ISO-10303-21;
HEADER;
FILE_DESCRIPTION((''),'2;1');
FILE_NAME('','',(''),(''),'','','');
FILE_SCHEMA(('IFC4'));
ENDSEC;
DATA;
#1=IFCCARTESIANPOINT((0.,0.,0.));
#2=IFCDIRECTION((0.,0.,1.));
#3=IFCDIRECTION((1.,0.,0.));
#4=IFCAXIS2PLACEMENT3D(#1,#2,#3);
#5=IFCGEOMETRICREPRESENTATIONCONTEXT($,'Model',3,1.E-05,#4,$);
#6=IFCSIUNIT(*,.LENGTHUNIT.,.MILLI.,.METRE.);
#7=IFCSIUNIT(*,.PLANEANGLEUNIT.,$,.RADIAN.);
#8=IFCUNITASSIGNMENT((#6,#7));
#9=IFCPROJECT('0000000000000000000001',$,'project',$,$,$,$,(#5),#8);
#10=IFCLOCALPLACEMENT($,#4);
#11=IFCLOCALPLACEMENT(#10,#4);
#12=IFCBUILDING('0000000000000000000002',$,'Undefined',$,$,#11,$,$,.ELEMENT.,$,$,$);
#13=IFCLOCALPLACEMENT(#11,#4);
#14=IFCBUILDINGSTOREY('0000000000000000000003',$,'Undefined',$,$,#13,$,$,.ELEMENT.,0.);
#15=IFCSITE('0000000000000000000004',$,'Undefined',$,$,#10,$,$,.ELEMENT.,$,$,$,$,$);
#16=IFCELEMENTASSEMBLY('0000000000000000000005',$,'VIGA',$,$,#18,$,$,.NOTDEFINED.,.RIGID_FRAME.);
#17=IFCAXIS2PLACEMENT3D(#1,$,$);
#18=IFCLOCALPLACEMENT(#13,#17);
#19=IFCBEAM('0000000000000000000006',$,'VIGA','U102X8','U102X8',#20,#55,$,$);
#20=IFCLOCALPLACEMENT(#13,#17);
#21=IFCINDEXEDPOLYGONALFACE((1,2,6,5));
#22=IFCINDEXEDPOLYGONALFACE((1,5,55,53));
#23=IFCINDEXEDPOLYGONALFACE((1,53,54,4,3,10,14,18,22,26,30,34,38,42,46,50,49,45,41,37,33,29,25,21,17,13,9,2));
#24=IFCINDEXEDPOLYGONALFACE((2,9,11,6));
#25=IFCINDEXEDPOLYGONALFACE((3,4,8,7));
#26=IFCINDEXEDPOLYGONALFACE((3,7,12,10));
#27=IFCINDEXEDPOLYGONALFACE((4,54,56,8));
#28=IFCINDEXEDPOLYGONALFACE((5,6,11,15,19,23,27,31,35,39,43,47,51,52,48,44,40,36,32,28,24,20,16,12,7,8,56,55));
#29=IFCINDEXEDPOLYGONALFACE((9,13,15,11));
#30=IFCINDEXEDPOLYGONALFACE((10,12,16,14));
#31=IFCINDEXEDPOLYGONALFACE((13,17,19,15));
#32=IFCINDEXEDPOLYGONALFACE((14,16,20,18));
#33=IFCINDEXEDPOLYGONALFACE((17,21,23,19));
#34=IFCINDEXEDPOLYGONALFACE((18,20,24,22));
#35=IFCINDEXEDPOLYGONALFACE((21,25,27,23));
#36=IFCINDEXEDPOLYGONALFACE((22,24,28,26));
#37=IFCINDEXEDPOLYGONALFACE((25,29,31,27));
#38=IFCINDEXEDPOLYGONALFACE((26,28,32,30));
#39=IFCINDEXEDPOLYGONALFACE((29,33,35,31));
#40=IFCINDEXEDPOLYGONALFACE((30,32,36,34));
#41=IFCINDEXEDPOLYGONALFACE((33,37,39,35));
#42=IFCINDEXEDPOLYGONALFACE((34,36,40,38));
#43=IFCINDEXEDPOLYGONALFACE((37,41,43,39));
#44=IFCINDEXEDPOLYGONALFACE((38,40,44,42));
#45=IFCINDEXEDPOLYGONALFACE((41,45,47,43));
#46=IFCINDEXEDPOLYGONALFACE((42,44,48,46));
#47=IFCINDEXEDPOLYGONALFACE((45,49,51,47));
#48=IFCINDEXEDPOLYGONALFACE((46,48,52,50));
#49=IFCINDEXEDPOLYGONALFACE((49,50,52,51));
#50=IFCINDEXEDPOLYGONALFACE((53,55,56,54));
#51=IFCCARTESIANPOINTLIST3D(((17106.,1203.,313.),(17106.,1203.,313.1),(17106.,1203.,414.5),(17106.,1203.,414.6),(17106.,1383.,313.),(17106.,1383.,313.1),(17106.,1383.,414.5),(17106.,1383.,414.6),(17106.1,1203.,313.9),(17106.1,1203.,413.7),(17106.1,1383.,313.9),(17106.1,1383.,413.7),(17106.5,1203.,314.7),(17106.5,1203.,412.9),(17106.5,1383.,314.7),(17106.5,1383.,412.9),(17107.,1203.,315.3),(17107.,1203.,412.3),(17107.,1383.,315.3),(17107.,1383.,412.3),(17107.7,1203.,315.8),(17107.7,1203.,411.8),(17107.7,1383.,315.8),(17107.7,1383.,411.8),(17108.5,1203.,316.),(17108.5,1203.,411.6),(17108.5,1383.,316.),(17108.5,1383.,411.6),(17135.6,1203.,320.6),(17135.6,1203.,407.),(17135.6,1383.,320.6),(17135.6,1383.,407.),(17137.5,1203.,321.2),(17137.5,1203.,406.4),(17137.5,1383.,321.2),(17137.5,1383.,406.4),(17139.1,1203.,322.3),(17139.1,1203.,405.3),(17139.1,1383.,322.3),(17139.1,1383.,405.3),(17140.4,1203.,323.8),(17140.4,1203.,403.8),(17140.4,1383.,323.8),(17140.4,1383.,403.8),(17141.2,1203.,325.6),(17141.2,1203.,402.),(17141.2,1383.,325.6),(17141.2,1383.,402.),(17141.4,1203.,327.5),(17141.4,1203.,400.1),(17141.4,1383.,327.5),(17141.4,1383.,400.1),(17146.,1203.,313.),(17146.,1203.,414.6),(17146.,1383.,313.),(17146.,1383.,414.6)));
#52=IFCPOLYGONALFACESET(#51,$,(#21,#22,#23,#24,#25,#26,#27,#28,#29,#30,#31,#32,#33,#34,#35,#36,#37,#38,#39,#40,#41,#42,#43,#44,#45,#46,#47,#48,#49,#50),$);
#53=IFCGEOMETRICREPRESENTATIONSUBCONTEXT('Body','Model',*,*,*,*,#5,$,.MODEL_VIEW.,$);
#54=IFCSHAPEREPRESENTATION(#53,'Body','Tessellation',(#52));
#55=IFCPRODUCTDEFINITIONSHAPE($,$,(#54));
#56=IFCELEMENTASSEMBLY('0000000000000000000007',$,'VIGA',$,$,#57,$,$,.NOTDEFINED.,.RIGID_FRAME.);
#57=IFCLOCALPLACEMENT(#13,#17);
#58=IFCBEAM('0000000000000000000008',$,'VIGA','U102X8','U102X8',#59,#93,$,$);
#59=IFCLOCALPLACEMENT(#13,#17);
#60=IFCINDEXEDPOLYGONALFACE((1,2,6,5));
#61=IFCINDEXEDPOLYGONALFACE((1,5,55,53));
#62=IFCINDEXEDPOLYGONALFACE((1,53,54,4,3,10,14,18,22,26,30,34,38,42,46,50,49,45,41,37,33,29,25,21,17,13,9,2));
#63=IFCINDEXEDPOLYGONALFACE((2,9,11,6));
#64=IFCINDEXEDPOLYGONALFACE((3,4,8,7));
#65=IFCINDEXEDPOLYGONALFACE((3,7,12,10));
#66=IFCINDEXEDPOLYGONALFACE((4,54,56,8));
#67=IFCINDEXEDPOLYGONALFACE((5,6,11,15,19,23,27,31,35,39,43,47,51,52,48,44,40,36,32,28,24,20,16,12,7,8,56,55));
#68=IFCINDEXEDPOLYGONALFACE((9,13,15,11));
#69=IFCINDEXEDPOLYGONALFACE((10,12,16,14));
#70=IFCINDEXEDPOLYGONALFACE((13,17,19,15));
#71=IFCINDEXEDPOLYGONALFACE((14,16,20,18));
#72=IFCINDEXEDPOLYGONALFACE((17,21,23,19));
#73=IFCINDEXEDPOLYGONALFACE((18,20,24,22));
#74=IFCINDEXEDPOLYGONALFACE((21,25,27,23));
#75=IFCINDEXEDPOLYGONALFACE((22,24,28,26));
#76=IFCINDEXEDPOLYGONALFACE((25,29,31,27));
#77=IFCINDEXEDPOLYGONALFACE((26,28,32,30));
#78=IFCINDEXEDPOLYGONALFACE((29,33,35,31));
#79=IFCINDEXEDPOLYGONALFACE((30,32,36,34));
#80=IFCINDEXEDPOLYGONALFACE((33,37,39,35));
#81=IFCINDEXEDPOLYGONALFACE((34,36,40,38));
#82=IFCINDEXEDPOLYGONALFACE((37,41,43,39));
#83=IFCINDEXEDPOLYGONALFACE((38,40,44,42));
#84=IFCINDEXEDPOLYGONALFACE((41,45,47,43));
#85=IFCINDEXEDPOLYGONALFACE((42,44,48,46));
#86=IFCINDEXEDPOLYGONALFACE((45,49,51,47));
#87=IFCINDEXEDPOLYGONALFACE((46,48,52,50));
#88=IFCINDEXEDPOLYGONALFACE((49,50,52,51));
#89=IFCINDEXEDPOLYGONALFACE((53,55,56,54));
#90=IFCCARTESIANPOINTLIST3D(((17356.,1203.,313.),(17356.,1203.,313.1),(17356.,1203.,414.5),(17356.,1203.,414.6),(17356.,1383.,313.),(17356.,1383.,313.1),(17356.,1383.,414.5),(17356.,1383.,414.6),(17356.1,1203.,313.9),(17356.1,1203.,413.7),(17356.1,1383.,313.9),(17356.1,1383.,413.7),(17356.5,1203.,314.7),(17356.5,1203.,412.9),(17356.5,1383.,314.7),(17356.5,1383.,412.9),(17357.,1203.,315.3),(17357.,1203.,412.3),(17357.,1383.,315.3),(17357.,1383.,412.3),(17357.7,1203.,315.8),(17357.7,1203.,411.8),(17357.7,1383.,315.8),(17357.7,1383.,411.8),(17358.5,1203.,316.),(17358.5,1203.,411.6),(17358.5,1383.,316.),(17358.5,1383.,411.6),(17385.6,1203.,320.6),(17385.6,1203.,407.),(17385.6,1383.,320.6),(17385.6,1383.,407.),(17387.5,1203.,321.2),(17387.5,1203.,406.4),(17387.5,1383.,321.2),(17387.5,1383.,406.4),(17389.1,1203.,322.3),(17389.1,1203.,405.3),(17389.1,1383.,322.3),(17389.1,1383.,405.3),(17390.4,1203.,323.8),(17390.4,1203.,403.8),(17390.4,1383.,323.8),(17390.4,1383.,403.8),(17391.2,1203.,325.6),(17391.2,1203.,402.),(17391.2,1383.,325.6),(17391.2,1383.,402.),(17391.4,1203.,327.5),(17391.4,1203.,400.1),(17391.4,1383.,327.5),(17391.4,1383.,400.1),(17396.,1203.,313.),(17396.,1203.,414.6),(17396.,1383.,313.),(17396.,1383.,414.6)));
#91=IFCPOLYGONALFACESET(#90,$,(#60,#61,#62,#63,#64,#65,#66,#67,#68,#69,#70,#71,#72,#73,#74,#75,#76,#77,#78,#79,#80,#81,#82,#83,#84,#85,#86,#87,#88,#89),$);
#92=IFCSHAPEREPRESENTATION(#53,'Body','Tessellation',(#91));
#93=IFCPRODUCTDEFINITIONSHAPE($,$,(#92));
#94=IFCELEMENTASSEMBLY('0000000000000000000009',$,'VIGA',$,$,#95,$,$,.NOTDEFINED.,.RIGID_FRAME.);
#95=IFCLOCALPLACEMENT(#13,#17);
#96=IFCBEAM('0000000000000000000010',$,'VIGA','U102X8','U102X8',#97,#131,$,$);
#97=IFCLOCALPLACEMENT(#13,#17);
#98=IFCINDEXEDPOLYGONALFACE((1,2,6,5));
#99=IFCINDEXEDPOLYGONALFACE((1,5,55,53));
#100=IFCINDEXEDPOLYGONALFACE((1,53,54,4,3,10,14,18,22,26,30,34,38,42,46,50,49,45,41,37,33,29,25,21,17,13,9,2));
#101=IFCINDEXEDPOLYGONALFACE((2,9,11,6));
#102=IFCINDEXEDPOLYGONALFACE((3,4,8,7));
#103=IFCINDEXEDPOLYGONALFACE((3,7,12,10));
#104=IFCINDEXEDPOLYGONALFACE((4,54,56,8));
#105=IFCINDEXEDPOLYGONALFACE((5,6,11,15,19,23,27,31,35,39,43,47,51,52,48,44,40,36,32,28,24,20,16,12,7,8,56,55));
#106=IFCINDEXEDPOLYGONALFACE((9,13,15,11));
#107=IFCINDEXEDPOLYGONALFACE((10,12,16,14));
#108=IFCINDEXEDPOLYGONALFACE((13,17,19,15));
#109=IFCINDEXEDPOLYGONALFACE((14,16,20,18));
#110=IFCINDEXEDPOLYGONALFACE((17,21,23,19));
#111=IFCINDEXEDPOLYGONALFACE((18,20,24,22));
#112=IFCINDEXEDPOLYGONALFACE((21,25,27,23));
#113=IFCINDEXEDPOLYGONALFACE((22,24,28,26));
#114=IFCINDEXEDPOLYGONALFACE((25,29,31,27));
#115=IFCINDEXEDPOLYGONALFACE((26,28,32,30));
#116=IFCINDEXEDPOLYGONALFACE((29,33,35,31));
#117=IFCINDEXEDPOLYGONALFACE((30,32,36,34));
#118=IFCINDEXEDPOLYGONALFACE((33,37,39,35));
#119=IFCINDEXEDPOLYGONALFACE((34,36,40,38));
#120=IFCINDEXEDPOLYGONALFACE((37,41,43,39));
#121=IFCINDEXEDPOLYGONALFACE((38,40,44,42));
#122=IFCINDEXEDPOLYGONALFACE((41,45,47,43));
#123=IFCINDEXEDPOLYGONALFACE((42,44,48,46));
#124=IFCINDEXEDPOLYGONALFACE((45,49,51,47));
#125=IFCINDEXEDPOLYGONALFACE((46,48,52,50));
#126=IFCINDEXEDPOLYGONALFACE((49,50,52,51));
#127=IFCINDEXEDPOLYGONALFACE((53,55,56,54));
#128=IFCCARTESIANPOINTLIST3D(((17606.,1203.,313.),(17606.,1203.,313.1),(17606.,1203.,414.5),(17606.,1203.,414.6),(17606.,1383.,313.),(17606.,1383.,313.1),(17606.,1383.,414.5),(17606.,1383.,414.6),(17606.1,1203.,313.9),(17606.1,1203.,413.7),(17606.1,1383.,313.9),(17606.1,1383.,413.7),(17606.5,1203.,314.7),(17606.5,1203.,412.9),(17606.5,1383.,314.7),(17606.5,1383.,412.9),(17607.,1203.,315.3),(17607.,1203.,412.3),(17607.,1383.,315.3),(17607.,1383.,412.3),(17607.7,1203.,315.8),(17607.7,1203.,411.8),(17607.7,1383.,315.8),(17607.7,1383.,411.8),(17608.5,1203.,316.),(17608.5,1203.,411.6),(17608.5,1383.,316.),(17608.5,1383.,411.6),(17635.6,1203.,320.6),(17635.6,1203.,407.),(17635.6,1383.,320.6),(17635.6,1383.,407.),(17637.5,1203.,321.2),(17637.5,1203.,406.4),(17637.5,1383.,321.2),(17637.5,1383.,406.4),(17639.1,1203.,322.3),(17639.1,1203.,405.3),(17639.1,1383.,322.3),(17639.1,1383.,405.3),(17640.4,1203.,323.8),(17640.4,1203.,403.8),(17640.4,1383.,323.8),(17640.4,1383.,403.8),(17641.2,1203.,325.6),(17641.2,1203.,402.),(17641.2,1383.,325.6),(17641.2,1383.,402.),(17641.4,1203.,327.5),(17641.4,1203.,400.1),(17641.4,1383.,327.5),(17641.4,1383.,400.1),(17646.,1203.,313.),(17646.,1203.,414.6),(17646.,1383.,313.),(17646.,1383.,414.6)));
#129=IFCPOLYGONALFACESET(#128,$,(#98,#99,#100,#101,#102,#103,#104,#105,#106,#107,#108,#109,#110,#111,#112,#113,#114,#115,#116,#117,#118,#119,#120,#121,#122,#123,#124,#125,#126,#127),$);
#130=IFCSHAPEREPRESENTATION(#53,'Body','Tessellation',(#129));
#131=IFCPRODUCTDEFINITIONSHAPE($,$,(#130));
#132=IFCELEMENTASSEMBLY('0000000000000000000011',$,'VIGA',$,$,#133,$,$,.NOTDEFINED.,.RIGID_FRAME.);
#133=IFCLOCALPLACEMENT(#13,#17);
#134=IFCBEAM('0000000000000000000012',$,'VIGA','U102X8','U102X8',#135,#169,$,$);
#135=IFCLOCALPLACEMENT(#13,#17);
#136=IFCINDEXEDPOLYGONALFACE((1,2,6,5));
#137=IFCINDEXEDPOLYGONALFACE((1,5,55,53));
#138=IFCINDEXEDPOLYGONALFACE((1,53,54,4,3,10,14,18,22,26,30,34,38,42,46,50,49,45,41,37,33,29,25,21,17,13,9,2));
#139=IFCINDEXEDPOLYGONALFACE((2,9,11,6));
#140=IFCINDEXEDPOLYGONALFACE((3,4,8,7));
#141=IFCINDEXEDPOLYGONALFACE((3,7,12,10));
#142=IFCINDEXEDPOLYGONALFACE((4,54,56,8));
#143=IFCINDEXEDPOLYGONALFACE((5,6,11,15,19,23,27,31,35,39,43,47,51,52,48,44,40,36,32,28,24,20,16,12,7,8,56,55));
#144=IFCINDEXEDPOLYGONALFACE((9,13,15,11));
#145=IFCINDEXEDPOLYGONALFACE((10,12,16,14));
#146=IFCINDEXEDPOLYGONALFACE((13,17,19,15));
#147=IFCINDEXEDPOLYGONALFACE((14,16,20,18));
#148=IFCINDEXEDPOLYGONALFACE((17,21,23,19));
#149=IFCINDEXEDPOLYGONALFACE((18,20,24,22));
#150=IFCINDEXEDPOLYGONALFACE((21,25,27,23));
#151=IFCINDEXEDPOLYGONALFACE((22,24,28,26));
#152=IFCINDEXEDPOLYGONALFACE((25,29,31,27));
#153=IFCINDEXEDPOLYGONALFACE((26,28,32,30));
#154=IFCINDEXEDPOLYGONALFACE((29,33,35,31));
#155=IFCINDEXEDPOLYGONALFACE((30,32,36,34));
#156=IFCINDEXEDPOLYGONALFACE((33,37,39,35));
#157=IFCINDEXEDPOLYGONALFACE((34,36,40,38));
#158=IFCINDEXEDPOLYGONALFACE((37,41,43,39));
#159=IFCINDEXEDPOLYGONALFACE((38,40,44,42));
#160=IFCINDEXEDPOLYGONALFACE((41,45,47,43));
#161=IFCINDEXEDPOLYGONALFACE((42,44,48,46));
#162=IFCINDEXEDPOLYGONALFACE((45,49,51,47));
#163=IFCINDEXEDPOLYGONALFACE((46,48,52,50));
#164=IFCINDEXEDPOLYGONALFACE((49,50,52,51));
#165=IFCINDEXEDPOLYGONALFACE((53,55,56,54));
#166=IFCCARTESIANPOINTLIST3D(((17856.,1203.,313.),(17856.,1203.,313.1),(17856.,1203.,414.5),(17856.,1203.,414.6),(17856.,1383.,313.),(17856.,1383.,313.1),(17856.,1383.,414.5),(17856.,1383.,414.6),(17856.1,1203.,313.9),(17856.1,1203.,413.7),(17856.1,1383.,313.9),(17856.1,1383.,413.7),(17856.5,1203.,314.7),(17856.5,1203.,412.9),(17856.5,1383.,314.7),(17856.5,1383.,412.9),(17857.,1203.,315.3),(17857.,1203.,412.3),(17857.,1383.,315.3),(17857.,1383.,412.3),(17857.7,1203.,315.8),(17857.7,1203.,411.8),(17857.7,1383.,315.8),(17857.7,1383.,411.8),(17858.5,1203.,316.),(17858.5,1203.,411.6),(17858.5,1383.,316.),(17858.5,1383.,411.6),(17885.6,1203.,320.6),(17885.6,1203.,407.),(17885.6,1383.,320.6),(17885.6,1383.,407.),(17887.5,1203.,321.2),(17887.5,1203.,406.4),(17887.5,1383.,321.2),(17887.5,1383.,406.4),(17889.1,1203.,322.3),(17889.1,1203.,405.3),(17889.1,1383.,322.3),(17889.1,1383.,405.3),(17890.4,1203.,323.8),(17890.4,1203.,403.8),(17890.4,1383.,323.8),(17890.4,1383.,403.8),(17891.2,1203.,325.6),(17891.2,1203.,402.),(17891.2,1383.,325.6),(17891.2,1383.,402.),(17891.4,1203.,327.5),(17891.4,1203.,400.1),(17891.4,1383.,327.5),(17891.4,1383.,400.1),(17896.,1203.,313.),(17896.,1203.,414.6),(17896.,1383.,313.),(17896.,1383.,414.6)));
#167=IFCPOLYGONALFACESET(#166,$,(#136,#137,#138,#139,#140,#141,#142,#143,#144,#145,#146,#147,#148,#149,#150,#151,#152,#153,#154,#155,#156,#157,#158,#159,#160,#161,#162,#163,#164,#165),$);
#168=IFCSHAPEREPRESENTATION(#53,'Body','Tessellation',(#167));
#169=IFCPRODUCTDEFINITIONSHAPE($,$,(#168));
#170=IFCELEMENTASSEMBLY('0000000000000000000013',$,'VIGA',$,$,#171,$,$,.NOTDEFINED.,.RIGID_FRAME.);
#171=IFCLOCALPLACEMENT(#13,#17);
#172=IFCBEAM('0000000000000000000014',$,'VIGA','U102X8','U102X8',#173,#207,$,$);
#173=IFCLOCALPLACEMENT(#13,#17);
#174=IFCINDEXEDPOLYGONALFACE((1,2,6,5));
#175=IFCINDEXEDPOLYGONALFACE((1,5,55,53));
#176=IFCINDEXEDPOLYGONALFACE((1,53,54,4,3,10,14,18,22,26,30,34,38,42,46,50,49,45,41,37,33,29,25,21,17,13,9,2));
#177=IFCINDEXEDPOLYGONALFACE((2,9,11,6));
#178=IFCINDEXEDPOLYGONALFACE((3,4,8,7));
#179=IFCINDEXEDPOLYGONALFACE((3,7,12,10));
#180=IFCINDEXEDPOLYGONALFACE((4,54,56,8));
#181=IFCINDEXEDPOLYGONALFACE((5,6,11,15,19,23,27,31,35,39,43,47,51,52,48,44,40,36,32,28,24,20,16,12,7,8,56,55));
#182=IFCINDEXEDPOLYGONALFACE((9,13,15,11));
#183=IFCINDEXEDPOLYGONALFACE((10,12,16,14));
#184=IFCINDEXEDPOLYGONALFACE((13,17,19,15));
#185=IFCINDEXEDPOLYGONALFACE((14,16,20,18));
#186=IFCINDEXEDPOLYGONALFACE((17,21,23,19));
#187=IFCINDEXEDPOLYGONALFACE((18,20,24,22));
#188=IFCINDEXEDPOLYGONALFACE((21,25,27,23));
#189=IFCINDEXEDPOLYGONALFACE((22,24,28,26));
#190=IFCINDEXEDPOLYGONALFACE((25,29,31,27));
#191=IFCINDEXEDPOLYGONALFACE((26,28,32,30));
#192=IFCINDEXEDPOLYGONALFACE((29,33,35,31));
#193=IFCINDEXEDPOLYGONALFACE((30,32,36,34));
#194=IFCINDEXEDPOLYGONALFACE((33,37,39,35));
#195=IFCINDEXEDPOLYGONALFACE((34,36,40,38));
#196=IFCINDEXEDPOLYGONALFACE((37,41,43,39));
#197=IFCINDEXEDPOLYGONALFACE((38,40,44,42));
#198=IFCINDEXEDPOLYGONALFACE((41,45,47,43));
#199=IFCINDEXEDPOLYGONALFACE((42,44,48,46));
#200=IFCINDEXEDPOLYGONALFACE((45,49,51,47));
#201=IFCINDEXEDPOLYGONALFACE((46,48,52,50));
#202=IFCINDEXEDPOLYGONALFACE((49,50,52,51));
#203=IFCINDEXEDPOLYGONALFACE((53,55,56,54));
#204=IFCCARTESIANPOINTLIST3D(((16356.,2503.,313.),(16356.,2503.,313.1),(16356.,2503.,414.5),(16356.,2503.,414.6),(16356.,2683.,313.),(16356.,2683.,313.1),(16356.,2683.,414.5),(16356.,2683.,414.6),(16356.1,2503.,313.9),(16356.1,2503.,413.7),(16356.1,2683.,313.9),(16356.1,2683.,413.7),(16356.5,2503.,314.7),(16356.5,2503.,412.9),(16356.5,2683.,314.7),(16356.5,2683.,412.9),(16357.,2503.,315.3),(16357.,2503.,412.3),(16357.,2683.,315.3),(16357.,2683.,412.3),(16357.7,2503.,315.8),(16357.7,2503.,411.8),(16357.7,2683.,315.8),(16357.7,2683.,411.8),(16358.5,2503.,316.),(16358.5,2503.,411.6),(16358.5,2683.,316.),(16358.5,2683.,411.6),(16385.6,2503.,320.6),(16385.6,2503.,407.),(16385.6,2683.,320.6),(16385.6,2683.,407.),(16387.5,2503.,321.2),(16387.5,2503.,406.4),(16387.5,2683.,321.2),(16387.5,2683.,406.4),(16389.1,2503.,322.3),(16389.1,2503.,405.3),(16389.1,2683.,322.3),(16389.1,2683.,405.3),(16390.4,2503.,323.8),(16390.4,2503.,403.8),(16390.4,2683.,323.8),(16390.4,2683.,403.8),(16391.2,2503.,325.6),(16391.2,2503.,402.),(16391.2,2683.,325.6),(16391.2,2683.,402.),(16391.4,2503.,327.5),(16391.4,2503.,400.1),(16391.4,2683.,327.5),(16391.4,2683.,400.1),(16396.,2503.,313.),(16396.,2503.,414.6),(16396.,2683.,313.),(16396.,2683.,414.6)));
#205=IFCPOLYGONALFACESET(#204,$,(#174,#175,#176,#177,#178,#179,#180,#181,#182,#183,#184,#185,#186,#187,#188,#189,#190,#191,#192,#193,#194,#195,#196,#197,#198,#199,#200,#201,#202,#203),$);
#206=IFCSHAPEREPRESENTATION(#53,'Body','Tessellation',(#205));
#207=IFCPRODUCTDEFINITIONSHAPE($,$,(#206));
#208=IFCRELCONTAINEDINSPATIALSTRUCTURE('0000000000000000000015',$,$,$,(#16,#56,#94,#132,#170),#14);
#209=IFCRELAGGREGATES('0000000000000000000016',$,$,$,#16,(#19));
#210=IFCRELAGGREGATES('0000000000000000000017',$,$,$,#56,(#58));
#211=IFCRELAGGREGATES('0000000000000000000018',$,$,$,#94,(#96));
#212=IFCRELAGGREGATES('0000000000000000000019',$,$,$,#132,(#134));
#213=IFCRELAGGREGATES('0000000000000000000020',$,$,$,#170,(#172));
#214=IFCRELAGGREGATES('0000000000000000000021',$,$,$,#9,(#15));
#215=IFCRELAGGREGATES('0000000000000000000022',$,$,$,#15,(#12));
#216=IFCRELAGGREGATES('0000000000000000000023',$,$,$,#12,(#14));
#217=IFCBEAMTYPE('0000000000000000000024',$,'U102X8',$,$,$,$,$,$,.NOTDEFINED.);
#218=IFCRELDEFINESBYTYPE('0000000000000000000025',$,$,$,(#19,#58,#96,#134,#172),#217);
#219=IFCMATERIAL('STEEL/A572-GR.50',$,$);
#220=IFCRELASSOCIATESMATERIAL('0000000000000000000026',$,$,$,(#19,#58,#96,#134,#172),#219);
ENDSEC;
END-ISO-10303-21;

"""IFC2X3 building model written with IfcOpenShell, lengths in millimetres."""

from ifc_helpers import new_model, si_unit, frame, origin_with_axes, origin_2d_with_axis, place, context, subcontext, project, spatial, u_section, extrude, material, type_object, element, aggregate, save


model = new_model("IFC2X3")

# Units and contexts
model_context = context("Model", 3, precision=1e-05, world=origin_with_axes())
body_context = subcontext(model_context, "Body", "Model", "MODEL_VIEW")
ifc_project = project(units=[si_unit("LENGTHUNIT", "METRE", prefix="MILLI"), si_unit("PLANEANGLEUNIT", "RADIAN")], contexts=[model_context])

# Site, building, storey
site_placement = place(None, origin_with_axes())
site = spatial("IfcSite", under=ifc_project, at=site_placement, Name="Undefined", CompositionType="ELEMENT")
building_placement = place(site_placement, origin_with_axes())
building = spatial("IfcBuilding", under=site, at=building_placement, Name="Undefined", CompositionType="ELEMENT")
storey_placement = place(building_placement, origin_with_axes())
storey = spatial("IfcBuildingStorey", under=building, at=storey_placement, Name="Undefined", CompositionType="ELEMENT", Elevation=0.0)

# Element assemblies, beams
ifc_material_1 = material(Name="STEEL/A572-GR.50")
beam_type_1 = type_object("IfcBeamType", Name="U102X8", PredefinedType="NOTDEFINED")
assembly_1_placement = place(storey_placement, origin_with_axes())
assembly_1 = element("IfcElementAssembly", 1, at=assembly_1_placement, inside=storey, Name="VIGA", AssemblyPlace="NOTDEFINED", PredefinedType="RIGID_FRAME")
beam_1_placement = place(assembly_1_placement, frame((17126.0, 1383.0, 363.8), z_axis=(0.0, 0.0, 1.0), x_axis=(0.0, -1.0, 0.0)))
beam_1 = element("IfcBeam", 2, at=beam_1_placement, type_object=beam_type_1, material=ifc_material_1, Name="VIGA", Description="U102X8", ObjectType="U102X8", context=body_context, shape_type="SweptSolid", body=[
    extrude(u_section(Depth=101.6, FlangeWidth=40.0, WebThickness=4.6, FlangeThickness=6.0, FilletRadius=7.0, EdgeRadius=3.0, FlangeSlope=0.16839, at=origin_2d_with_axis()), frame((180.0, 0.0, 0.0), z_axis=(-1.0, 0.0, 0.0), x_axis=(0.0, -1.0, 0.0)), (0.0, 0.0, 1.0), 180.0),
])
aggregate(assembly_1, [beam_1])
assembly_2_placement = place(storey_placement, origin_with_axes())
assembly_2 = element("IfcElementAssembly", 3, at=assembly_2_placement, inside=storey, Name="VIGA", AssemblyPlace="NOTDEFINED", PredefinedType="RIGID_FRAME")
beam_2_placement = place(assembly_2_placement, frame((17376.0, 1383.0, 363.8), z_axis=(0.0, 0.0, 1.0), x_axis=(0.0, -1.0, 0.0)))
beam_2 = element("IfcBeam", 4, at=beam_2_placement, type_object=beam_type_1, material=ifc_material_1, Name="VIGA", Description="U102X8", ObjectType="U102X8", context=body_context, shape_type="SweptSolid", body=[
    extrude(u_section(Depth=101.6, FlangeWidth=40.0, WebThickness=4.6, FlangeThickness=6.0, FilletRadius=7.0, EdgeRadius=3.0, FlangeSlope=0.16839, at=origin_2d_with_axis()), frame((180.0, 0.0, 0.0), z_axis=(-1.0, 0.0, 0.0), x_axis=(0.0, -1.0, 0.0)), (0.0, 0.0, 1.0), 180.0),
])
aggregate(assembly_2, [beam_2])
assembly_3_placement = place(storey_placement, origin_with_axes())
assembly_3 = element("IfcElementAssembly", 5, at=assembly_3_placement, inside=storey, Name="VIGA", AssemblyPlace="NOTDEFINED", PredefinedType="RIGID_FRAME")
beam_3_placement = place(assembly_3_placement, frame((17626.0, 1383.0, 363.8), z_axis=(0.0, 0.0, 1.0), x_axis=(0.0, -1.0, 0.0)))
beam_3 = element("IfcBeam", 6, at=beam_3_placement, type_object=beam_type_1, material=ifc_material_1, Name="VIGA", Description="U102X8", ObjectType="U102X8", context=body_context, shape_type="SweptSolid", body=[
    extrude(u_section(Depth=101.6, FlangeWidth=40.0, WebThickness=4.6, FlangeThickness=6.0, FilletRadius=7.0, EdgeRadius=3.0, FlangeSlope=0.16839, at=origin_2d_with_axis()), frame((180.0, 0.0, 0.0), z_axis=(-1.0, 0.0, 0.0), x_axis=(0.0, -1.0, 0.0)), (0.0, 0.0, 1.0), 180.0),
])
aggregate(assembly_3, [beam_3])
assembly_4_placement = place(storey_placement, origin_with_axes())
assembly_4 = element("IfcElementAssembly", 7, at=assembly_4_placement, inside=storey, Name="VIGA", AssemblyPlace="NOTDEFINED", PredefinedType="RIGID_FRAME")
beam_4_placement = place(assembly_4_placement, frame((17876.0, 1383.0, 363.8), z_axis=(0.0, 0.0, 1.0), x_axis=(0.0, -1.0, 0.0)))
beam_4 = element("IfcBeam", 8, at=beam_4_placement, type_object=beam_type_1, material=ifc_material_1, Name="VIGA", Description="U102X8", ObjectType="U102X8", context=body_context, shape_type="SweptSolid", body=[
    extrude(u_section(Depth=101.6, FlangeWidth=40.0, WebThickness=4.6, FlangeThickness=6.0, FilletRadius=7.0, EdgeRadius=3.0, FlangeSlope=0.16839, at=origin_2d_with_axis()), frame((180.0, 0.0, 0.0), z_axis=(-1.0, 0.0, 0.0), x_axis=(0.0, -1.0, 0.0)), (0.0, 0.0, 1.0), 180.0),
])
aggregate(assembly_4, [beam_4])
assembly_5_placement = place(storey_placement, origin_with_axes())
assembly_5 = element("IfcElementAssembly", 9, at=assembly_5_placement, inside=storey, Name="VIGA", AssemblyPlace="NOTDEFINED", PredefinedType="RIGID_FRAME")
beam_5_placement = place(assembly_5_placement, frame((16376.0, 2683.0, 363.8), z_axis=(0.0, 0.0, 1.0), x_axis=(0.0, -1.0, 0.0)))
beam_5 = element("IfcBeam", 10, at=beam_5_placement, type_object=beam_type_1, material=ifc_material_1, Name="VIGA", Description="U102X8", ObjectType="U102X8", context=body_context, shape_type="SweptSolid", body=[
    extrude(u_section(Depth=101.6, FlangeWidth=40.0, WebThickness=4.6, FlangeThickness=6.0, FilletRadius=7.0, EdgeRadius=3.0, FlangeSlope=0.16839, at=origin_2d_with_axis()), frame((180.0, 0.0, 0.0), z_axis=(-1.0, 0.0, 0.0), x_axis=(0.0, -1.0, 0.0)), (0.0, 0.0, 1.0), 180.0),
])
aggregate(assembly_5, [beam_5])

save(model, "model.ifc")
